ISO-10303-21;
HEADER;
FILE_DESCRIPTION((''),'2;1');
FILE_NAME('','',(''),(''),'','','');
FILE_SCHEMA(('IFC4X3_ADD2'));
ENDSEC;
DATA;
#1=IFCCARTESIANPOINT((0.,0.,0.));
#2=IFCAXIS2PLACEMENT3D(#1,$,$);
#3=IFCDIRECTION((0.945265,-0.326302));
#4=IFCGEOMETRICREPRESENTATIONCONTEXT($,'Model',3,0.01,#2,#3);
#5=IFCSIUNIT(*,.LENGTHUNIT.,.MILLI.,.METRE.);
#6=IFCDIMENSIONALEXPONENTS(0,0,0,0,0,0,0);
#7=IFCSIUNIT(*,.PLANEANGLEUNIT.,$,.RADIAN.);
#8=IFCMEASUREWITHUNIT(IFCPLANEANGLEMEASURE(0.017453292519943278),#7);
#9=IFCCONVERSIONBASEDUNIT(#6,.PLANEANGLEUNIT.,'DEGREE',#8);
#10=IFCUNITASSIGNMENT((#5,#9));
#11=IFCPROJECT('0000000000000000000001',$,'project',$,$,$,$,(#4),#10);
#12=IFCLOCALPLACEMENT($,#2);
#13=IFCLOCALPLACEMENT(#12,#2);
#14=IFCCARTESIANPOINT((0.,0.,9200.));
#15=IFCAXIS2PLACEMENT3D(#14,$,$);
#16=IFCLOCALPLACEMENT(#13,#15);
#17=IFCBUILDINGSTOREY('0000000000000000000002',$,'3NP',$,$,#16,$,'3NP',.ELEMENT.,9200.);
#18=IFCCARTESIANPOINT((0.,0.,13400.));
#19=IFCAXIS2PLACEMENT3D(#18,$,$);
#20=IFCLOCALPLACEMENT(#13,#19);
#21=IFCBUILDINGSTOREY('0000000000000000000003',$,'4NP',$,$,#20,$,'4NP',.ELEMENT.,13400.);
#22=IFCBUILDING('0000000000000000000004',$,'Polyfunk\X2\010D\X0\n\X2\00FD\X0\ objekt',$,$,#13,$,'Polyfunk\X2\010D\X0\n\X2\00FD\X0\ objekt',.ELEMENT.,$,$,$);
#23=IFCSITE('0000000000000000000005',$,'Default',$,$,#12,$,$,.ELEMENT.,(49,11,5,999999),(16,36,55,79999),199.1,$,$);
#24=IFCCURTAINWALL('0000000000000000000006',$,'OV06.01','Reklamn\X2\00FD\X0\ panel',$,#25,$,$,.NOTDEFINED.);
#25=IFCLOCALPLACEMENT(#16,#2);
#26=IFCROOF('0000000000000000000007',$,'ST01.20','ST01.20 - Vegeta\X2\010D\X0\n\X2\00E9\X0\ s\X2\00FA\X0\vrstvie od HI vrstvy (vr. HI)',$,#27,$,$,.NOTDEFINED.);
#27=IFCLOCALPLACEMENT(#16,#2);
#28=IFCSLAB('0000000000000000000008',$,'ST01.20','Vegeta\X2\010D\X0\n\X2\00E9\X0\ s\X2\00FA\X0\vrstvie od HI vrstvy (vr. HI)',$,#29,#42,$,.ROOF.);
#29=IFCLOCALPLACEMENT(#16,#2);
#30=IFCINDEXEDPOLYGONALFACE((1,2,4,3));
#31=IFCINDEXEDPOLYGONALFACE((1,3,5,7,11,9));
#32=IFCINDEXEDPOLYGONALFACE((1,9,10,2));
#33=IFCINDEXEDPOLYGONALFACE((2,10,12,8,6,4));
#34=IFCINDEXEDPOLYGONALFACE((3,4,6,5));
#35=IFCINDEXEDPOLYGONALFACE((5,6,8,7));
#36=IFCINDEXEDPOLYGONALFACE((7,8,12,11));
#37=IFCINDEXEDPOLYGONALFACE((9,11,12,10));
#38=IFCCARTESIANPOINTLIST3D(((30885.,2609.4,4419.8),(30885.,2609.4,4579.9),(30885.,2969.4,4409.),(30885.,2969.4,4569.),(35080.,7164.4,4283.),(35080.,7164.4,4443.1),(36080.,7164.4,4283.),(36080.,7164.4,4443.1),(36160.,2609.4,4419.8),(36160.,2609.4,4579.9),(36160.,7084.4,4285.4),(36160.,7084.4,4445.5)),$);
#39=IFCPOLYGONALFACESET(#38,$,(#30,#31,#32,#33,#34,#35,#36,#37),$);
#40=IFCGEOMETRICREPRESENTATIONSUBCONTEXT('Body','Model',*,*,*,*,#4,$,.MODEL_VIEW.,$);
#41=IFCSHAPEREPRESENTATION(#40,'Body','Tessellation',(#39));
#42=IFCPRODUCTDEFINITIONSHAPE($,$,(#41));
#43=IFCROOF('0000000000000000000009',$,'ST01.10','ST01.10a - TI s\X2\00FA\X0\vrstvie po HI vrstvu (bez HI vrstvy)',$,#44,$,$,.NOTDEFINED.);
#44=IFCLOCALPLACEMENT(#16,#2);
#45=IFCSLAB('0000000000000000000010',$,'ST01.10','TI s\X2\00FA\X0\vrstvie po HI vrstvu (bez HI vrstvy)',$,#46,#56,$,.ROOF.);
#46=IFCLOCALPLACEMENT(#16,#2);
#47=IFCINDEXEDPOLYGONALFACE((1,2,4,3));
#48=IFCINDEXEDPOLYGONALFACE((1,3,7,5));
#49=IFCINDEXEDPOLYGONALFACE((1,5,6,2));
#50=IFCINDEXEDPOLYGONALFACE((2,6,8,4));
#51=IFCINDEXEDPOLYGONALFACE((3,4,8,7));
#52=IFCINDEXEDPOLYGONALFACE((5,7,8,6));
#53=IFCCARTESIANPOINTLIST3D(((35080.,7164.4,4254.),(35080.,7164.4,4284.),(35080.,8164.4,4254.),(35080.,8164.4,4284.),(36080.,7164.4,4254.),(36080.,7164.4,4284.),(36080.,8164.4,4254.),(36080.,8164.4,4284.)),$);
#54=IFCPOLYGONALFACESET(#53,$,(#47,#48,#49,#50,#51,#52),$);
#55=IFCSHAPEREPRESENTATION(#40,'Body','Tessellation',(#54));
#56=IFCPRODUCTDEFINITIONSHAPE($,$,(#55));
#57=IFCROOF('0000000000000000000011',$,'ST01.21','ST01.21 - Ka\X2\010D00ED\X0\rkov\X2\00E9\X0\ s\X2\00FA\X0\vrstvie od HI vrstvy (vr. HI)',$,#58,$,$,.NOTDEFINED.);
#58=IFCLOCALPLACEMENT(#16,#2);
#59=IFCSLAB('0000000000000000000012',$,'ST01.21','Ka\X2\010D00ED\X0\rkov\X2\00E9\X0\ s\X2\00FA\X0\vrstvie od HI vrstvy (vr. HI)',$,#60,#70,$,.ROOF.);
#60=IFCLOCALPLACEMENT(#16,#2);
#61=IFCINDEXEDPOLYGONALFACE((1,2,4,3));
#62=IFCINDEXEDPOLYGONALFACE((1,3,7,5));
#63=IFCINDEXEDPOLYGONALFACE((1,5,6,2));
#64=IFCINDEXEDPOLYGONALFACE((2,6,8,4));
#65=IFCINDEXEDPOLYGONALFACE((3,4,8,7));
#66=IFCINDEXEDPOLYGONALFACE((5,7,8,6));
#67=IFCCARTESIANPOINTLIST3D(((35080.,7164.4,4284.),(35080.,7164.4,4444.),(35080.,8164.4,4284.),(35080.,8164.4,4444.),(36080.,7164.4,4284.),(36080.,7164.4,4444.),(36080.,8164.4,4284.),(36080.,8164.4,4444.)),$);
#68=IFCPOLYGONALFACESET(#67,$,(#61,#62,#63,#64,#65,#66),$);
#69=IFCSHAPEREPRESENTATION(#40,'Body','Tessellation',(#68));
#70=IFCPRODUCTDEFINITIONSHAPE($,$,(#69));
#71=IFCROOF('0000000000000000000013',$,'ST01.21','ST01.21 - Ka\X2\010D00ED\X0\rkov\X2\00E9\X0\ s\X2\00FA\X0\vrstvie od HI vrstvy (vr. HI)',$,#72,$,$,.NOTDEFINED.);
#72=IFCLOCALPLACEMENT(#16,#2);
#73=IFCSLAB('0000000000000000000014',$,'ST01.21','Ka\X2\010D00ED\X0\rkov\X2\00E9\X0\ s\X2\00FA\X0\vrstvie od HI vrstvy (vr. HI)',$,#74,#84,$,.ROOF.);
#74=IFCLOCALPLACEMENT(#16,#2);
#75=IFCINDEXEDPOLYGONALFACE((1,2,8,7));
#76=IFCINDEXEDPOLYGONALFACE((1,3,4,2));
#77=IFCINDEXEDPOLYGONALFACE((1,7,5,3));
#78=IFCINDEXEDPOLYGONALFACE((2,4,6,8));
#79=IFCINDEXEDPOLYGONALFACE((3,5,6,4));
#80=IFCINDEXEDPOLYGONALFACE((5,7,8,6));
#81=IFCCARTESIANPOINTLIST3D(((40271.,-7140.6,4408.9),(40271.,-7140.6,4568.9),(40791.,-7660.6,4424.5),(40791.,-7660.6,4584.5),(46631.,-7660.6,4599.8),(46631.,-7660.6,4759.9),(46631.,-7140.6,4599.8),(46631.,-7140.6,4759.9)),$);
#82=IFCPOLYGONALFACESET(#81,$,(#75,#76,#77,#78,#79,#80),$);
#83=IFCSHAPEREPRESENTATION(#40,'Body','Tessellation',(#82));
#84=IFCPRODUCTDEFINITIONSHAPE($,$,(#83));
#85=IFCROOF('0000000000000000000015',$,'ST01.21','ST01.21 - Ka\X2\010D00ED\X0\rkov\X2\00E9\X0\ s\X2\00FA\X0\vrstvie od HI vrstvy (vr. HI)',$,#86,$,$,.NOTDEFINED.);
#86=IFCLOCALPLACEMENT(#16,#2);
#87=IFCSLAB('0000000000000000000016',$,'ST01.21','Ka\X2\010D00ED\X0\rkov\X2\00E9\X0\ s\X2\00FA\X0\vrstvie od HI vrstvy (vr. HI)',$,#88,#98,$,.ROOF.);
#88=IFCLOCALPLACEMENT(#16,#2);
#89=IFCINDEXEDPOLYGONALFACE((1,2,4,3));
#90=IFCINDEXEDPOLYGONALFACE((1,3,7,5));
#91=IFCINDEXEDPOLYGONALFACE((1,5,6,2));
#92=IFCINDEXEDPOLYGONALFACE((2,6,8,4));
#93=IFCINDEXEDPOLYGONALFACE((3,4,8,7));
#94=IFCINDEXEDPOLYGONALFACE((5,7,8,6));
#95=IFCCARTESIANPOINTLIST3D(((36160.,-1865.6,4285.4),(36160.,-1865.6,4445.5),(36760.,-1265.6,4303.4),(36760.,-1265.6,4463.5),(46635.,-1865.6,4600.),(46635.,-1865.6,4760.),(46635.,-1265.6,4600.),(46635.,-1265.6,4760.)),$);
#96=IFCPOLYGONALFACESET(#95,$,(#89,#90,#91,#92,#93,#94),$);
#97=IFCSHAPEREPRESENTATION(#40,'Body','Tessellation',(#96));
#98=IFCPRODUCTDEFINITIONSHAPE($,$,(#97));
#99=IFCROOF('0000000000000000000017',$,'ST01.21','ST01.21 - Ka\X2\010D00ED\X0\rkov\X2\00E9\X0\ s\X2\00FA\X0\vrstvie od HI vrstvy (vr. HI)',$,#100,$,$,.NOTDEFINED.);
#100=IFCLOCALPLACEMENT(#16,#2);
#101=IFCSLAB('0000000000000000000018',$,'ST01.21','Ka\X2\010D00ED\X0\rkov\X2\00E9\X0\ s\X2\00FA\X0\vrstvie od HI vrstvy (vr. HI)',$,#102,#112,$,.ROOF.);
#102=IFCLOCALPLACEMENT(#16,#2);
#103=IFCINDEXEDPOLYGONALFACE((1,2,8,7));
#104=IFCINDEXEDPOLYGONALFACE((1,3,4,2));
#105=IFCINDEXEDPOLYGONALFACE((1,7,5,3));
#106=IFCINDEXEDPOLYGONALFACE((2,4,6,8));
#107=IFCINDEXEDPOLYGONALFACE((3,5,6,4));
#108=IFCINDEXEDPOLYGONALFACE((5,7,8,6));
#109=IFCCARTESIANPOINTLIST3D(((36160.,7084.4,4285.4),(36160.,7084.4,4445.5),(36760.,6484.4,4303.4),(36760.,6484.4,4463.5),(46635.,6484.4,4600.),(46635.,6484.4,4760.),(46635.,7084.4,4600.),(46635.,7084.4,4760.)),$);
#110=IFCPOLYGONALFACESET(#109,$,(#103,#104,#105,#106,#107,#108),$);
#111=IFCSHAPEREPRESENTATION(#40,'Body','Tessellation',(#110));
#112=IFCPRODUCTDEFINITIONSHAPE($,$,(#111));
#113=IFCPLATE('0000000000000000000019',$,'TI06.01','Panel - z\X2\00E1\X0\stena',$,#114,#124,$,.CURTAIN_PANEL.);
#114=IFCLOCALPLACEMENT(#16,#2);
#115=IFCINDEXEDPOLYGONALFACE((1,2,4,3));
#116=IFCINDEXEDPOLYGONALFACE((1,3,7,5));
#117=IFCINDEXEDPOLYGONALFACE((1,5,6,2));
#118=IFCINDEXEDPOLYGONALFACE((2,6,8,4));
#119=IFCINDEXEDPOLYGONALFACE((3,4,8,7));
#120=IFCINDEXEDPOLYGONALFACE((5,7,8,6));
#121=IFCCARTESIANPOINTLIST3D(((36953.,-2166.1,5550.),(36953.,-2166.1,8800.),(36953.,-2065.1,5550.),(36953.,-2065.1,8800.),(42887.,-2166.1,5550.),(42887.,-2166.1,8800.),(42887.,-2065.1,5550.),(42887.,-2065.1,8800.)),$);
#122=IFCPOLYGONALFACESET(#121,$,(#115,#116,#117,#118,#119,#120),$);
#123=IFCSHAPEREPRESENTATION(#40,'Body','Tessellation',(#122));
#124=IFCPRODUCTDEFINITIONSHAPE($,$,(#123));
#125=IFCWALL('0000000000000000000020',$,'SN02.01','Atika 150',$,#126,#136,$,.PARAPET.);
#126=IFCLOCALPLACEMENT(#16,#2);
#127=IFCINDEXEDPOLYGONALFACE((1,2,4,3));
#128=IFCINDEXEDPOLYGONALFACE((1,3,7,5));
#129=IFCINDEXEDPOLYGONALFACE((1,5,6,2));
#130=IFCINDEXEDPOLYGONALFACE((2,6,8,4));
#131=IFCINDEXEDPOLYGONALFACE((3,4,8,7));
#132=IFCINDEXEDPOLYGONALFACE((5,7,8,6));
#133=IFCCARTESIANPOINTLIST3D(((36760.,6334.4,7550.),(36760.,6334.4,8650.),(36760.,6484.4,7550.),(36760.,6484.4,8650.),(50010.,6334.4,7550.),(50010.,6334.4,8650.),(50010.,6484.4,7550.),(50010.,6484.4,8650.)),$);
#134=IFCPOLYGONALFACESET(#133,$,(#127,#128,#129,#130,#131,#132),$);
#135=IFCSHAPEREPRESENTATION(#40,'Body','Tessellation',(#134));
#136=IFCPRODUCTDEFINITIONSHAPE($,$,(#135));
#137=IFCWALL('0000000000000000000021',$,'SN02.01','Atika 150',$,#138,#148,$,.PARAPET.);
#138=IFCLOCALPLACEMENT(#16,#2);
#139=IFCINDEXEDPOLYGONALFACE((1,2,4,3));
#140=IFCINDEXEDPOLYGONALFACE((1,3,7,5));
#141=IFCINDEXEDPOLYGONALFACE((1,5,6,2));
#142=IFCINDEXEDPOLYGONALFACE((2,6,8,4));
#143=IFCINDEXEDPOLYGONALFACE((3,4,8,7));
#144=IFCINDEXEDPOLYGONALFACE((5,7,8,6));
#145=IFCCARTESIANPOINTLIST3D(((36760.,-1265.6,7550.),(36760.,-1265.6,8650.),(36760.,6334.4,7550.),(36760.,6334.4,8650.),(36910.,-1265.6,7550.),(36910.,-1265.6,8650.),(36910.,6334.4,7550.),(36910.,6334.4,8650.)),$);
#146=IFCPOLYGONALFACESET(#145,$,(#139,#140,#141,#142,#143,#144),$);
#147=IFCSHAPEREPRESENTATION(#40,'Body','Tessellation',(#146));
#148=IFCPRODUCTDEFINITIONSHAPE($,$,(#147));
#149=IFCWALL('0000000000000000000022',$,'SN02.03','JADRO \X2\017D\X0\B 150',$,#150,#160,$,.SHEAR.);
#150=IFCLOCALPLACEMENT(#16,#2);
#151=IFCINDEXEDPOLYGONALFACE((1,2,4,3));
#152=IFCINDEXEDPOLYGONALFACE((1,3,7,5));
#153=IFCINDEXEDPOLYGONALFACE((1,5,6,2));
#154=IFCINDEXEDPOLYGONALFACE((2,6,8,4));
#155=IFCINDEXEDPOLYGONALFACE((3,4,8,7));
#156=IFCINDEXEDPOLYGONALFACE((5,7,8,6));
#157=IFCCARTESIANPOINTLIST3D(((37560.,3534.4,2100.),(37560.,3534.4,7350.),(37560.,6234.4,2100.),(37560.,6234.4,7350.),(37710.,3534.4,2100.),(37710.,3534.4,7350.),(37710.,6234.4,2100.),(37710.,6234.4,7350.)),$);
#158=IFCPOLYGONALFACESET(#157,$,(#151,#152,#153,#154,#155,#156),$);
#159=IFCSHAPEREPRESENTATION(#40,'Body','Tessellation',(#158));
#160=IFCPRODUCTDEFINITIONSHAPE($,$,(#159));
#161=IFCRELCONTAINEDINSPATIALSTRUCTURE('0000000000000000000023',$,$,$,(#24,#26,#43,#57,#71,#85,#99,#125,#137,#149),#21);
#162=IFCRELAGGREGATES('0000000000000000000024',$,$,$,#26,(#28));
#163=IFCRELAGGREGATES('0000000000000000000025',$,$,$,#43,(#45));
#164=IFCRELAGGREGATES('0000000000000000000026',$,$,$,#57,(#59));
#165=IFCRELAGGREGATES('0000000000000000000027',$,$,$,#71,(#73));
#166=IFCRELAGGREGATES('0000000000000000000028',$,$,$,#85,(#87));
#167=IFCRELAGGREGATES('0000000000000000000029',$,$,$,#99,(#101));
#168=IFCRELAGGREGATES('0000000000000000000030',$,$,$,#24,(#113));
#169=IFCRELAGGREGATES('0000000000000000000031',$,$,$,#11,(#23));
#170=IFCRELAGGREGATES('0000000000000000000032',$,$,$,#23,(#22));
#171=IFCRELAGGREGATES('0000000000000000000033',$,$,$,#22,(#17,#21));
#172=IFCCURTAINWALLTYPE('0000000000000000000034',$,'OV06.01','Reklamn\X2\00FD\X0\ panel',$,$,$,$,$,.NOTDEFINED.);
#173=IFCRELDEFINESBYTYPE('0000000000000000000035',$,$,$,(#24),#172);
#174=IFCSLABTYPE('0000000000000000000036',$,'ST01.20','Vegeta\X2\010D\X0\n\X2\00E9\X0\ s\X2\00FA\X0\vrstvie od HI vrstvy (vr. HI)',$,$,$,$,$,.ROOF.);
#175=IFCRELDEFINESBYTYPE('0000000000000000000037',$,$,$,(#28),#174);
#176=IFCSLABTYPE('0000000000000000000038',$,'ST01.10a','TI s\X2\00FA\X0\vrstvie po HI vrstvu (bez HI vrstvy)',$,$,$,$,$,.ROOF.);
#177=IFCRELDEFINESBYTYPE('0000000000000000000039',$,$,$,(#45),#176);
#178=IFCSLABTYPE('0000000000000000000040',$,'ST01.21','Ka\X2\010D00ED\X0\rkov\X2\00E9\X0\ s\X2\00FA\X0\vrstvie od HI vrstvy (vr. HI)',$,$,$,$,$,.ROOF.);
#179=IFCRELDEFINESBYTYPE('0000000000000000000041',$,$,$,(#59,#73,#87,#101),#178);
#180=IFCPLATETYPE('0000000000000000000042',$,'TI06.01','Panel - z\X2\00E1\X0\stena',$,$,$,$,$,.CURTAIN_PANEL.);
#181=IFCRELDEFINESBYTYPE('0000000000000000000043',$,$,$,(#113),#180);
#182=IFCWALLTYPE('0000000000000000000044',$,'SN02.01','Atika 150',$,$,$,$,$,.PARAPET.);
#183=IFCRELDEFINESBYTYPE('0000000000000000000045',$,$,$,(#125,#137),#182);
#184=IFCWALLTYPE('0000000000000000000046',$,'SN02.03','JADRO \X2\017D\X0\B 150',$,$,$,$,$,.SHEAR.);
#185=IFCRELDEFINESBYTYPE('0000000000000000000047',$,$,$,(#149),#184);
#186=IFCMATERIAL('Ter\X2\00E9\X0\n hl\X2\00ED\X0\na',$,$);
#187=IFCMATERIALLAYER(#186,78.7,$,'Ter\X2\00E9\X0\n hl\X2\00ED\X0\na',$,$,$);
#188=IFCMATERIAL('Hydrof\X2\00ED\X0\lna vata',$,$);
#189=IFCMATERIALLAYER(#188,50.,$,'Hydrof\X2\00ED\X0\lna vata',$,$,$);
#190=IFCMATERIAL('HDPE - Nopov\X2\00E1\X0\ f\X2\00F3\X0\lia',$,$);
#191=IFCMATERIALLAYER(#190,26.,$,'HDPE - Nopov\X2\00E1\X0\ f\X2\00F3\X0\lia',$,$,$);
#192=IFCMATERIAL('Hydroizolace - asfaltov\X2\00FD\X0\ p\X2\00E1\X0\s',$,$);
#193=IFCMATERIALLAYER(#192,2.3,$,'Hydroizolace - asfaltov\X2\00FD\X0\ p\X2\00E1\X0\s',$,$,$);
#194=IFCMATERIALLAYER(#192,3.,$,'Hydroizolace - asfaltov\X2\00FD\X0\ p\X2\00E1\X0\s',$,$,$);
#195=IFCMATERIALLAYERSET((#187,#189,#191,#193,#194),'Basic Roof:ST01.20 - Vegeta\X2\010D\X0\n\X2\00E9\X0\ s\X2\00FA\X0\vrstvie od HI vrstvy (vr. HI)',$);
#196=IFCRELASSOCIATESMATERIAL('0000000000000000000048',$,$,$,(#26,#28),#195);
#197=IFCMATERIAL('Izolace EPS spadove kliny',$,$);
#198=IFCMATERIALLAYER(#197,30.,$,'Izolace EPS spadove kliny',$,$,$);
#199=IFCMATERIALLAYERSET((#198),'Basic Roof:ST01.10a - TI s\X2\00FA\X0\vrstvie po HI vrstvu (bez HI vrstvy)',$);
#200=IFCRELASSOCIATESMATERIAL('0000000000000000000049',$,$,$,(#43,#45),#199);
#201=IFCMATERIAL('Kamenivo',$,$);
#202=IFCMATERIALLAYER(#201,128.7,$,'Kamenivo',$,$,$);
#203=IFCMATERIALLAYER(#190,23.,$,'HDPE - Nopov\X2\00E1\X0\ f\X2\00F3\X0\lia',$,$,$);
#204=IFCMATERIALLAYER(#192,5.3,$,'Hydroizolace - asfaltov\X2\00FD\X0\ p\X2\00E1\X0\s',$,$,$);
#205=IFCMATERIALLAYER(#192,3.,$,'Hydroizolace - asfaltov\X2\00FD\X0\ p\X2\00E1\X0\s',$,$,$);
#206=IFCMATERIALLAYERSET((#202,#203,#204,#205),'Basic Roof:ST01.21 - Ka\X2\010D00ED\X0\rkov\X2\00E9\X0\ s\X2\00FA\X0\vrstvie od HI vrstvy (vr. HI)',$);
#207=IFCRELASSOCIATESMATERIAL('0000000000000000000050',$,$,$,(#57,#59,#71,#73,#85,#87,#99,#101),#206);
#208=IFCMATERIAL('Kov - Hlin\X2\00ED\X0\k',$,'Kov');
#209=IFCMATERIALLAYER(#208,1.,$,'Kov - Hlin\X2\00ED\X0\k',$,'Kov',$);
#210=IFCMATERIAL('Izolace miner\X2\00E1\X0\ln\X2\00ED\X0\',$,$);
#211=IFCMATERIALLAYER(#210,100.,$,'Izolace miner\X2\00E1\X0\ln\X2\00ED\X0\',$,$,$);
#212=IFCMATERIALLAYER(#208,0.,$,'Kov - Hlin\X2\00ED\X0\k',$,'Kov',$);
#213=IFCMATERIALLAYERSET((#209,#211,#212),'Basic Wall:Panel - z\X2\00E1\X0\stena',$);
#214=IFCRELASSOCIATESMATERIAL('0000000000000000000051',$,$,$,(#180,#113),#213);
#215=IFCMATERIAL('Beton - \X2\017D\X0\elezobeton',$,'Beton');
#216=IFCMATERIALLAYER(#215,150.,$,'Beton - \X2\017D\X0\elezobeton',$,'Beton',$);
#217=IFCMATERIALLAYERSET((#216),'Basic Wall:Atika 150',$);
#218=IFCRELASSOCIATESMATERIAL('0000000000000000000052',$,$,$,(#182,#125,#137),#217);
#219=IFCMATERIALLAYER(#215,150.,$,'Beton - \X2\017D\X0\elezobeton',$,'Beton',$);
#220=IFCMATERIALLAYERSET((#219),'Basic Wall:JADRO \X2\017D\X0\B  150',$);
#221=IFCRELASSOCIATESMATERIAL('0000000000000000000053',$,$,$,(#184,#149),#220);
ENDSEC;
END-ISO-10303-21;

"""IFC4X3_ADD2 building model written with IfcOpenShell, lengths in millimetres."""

from ifc_helpers import new_model, entity, si_unit, converted_unit, direction, frame, frame_2d, origin, place, context, subcontext, project, spatial, polyline, rectangle, outline, extrude, material, layer, layer_set, layer_usage, type_object, element, aggregate, save


model = new_model("IFC4X3_ADD2")

# Units and contexts
model_context = context("Model", 3, precision=0.01, world=origin(), true_north=direction((0.945265, -0.326302)))
body_context = subcontext(model_context, "Body", "Model", "MODEL_VIEW")
ifc_project = project(units=[si_unit("LENGTHUNIT", "METRE", prefix="MILLI"), converted_unit("PLANEANGLEUNIT", "DEGREE", entity("IfcPlaneAngleMeasure", 0.017453292519943278), si_unit("PLANEANGLEUNIT", "RADIAN"), dimensions=[0, 0, 0, 0, 0, 0, 0])], contexts=[model_context])

# Site, building, storey
site_placement = place(None, origin())
site = spatial("IfcSite", under=ifc_project, at=site_placement, Name="Default", CompositionType="ELEMENT", RefLatitude=(49, 11, 5, 999999), RefLongitude=(16, 36, 55, 79999), RefElevation=199.1)
building_placement = place(site_placement, origin())
building = spatial("IfcBuilding", under=site, at=building_placement, Name="Polyfunkčný objekt", LongName="Polyfunkčný objekt", CompositionType="ELEMENT")
storey_1_placement = place(building_placement, frame((0.0, 0.0, 9200.0)))
storey_1 = spatial("IfcBuildingStorey", under=building, at=storey_1_placement, Name="3NP", LongName="3NP", CompositionType="ELEMENT", Elevation=9200.0)

# Shared definitions
storey_2_placement = place(building_placement, frame((0.0, 0.0, 13400.0)))
storey_2 = spatial("IfcBuildingStorey", under=building, at=storey_2_placement, Name="4NP", LongName="4NP", CompositionType="ELEMENT", Elevation=13400.0)

# Curtain wall
curtain_wall_type_1 = type_object("IfcCurtainWallType", Name="OV06.01", Description="Reklamný panel", PredefinedType="NOTDEFINED")
curtain_wall_1_placement = place(storey_2_placement, frame((0.0, 0.0, -13400.0)))
curtain_wall_1 = element("IfcCurtainWall", 1, at=curtain_wall_1_placement, inside=storey_2, type_object=curtain_wall_type_1, Name="OV06.01", Description="Reklamný panel", PredefinedType="NOTDEFINED")

# Roofs, slabs
ifc_material_1 = material(Name="Terén hlína")
ifc_layer_1 = layer(ifc_material_1, 78.7, Name="Terén hlína")
ifc_material_2 = material(Name="Hydrofílna vata")
ifc_layer_2 = layer(ifc_material_2, 50.0, Name="Hydrofílna vata")
ifc_material_3 = material(Name="HDPE - Nopová fólia")
ifc_layer_3 = layer(ifc_material_3, 26.0, Name="HDPE - Nopová fólia")
ifc_material_4 = material(Name="Hydroizolace - asfaltový pás")
ifc_layer_4 = layer(ifc_material_4, 2.3, Name="Hydroizolace - asfaltový pás")
ifc_layer_5 = layer(ifc_material_4, 3.0, Name="Hydroizolace - asfaltový pás")
ifc_layer_set_1 = layer_set([ifc_layer_1, ifc_layer_2, ifc_layer_3, ifc_layer_4, ifc_layer_5], Name="Basic Roof:ST01.20 - Vegetačné súvrstvie od HI vrstvy (vr. HI)")
slab_type_1 = type_object("IfcSlabType", Name="ST01.20", Description="Vegetačné súvrstvie od HI vrstvy (vr. HI)", PredefinedType="ROOF")
roof_1_placement = place(storey_2_placement, frame((30885.0, 2609.4, 83.0)))
roof_1 = element("IfcRoof", 2, at=roof_1_placement, inside=storey_2, material=ifc_layer_set_1, Name="ST01.20", Description="ST01.20 - Vegetačné súvrstvie od HI vrstvy (vr. HI)", PredefinedType="NOTDEFINED")
slab_1_placement = place(roof_1_placement, origin())
slab_1 = element("IfcSlab", 3, at=slab_1_placement, type_object=slab_type_1, material=ifc_layer_set_1, Name="ST01.20", Description="Vegetačné súvrstvie od HI vrstvy (vr. HI)", PredefinedType="ROOF", context=body_context, shape_type="SweptSolid", body=[
    extrude(outline(polyline([(1557.5, 2278.5), (-2637.5, -1918.4), (-2637.5, -2278.5), (2637.5, -2278.5), (2637.5, 2198.5), (2557.5, 2278.5), (1557.5, 2278.5)])), frame((2637.5, 2277.5, 68.4), z_axis=(0.0, 0.030015, 0.999549), x_axis=(1.0, 0.0, 0.0)), (0.0, -0.030015, 0.999549), 160.1),
])
aggregate(roof_1, [slab_1])
ifc_material_5 = material(Name="Izolace EPS spadove kliny")
ifc_layer_6 = layer(ifc_material_5, 30.0, Name="Izolace EPS spadove kliny")
ifc_layer_set_2 = layer_set([ifc_layer_6], Name="Basic Roof:ST01.10a - TI súvrstvie po HI vrstvu (bez HI vrstvy)")
roof_2_placement = place(storey_2_placement, frame((35080.0, 7164.4, 54.0)))
roof_2 = element("IfcRoof", 4, at=roof_2_placement, inside=storey_2, material=ifc_layer_set_2, Name="ST01.10", Description="ST01.10a - TI súvrstvie po HI vrstvu (bez HI vrstvy)", PredefinedType="NOTDEFINED")
slab_type_2 = type_object("IfcSlabType", Name="ST01.10a", Description="TI súvrstvie po HI vrstvu (bez HI vrstvy)", PredefinedType="ROOF")
slab_2_placement = place(roof_2_placement, origin())
slab_2 = element("IfcSlab", 5, at=slab_2_placement, type_object=slab_type_2, material=ifc_layer_set_2, Name="ST01.10", Description="TI súvrstvie po HI vrstvu (bez HI vrstvy)", PredefinedType="ROOF", context=body_context, shape_type="SweptSolid", body=[
    extrude(rectangle(XDim=1000.0, YDim=1000.0, at=frame_2d((0.0, 0.0), x_axis=(1.0, 0.0))), frame((500.0, 500.0, 0.0)), (0.0, 0.0, 1.0), 30.0),
])
aggregate(roof_2, [slab_2])
ifc_material_6 = material(Name="Kamenivo")
ifc_layer_7 = layer(ifc_material_6, 128.7, Name="Kamenivo")
ifc_layer_8 = layer(ifc_material_3, 23.0, Name="HDPE - Nopová fólia")
ifc_layer_9 = layer(ifc_material_4, 5.3, Name="Hydroizolace - asfaltový pás")
ifc_layer_10 = layer(ifc_material_4, 3.0, Name="Hydroizolace - asfaltový pás")
ifc_layer_set_3 = layer_set([ifc_layer_7, ifc_layer_8, ifc_layer_9, ifc_layer_10], Name="Basic Roof:ST01.21 - Kačírkové súvrstvie od HI vrstvy (vr. HI)")
roof_3_placement = place(storey_2_placement, frame((35080.0, 7164.4, 84.0)))
roof_3 = element("IfcRoof", 6, at=roof_3_placement, inside=storey_2, material=ifc_layer_set_3, Name="ST01.21", Description="ST01.21 - Kačírkové súvrstvie od HI vrstvy (vr. HI)", PredefinedType="NOTDEFINED")
slab_type_3 = type_object("IfcSlabType", Name="ST01.21", Description="Kačírkové súvrstvie od HI vrstvy (vr. HI)", PredefinedType="ROOF")
slab_3_placement = place(roof_3_placement, origin())
slab_3 = element("IfcSlab", 7, at=slab_3_placement, type_object=slab_type_3, material=ifc_layer_set_3, Name="ST01.21", Description="Kačírkové súvrstvie od HI vrstvy (vr. HI)", PredefinedType="ROOF", context=body_context, shape_type="SweptSolid", body=[
    extrude(rectangle(XDim=1000.0, YDim=1000.0, at=frame_2d((0.0, 0.0), x_axis=(1.0, 0.0))), frame((500.0, 500.0, 0.0)), (0.0, 0.0, 1.0), 160.0),
])
aggregate(roof_3, [slab_3])
roof_4_placement = place(storey_2_placement, frame((40271.0, -7660.6, 208.9)))
roof_4 = element("IfcRoof", 8, at=roof_4_placement, inside=storey_2, material=ifc_layer_set_3, Name="ST01.21", Description="ST01.21 - Kačírkové súvrstvie od HI vrstvy (vr. HI)", PredefinedType="NOTDEFINED")
slab_4_placement = place(roof_4_placement, origin())
slab_4 = element("IfcSlab", 9, at=slab_4_placement, type_object=slab_type_3, material=ifc_layer_set_3, Name="ST01.21", Description="Kačírkové súvrstvie od HI vrstvy (vr. HI)", PredefinedType="ROOF", context=body_context, shape_type="SweptSolid", body=[
    extrude(outline(polyline([(-2661.2, -260.0), (3181.4, -260.0), (3181.4, 260.0), (-3181.4, 260.0), (-2661.2, -260.0)])), frame((3180.0, 260.0, 95.5), z_axis=(-0.030015, 0.0, 0.999549), x_axis=(0.999549, 0.0, 0.030015)), (0.030015, 0.0, 0.999549), 160.1),
])
aggregate(roof_4, [slab_4])
roof_5_placement = place(storey_2_placement, frame((36160.0, -1865.6, 85.4)))
roof_5 = element("IfcRoof", 10, at=roof_5_placement, inside=storey_2, material=ifc_layer_set_3, Name="ST01.21", Description="ST01.21 - Kačírkové súvrstvie od HI vrstvy (vr. HI)", PredefinedType="NOTDEFINED")
slab_5_placement = place(roof_5_placement, origin())
slab_5 = element("IfcSlab", 11, at=slab_5_placement, type_object=slab_type_3, material=ifc_layer_set_3, Name="ST01.21", Description="Kačírkové súvrstvie od HI vrstvy (vr. HI)", PredefinedType="ROOF", context=body_context, shape_type="SweptSolid", body=[
    extrude(outline(polyline([(-5239.9, -300.0), (5239.9, -300.0), (5239.9, 300.0), (-4639.6, 300.0), (-5239.9, -300.0)])), frame((5237.5, 300.0, 157.3), z_axis=(-0.030015, 0.0, 0.999549), x_axis=(0.999549, 0.0, 0.030015)), (0.030015, 0.0, 0.999549), 160.1),
])
aggregate(roof_5, [slab_5])
roof_6_placement = place(storey_2_placement, frame((36160.0, 6484.4, 85.4)))
roof_6 = element("IfcRoof", 12, at=roof_6_placement, inside=storey_2, material=ifc_layer_set_3, Name="ST01.21", Description="ST01.21 - Kačírkové súvrstvie od HI vrstvy (vr. HI)", PredefinedType="NOTDEFINED")
slab_6_placement = place(roof_6_placement, origin())
slab_6 = element("IfcSlab", 13, at=slab_6_placement, type_object=slab_type_3, material=ifc_layer_set_3, Name="ST01.21", Description="Kačírkové súvrstvie od HI vrstvy (vr. HI)", PredefinedType="ROOF", context=body_context, shape_type="SweptSolid", body=[
    extrude(outline(polyline([(-4639.6, -300.0), (5239.9, -300.0), (5239.9, 300.0), (-5239.9, 300.0), (-4639.6, -300.0)])), frame((5237.5, 300.0, 157.3), z_axis=(-0.030015, 0.0, 0.999549), x_axis=(0.999549, 0.0, 0.030015)), (0.030015, 0.0, 0.999549), 160.1),
])
aggregate(roof_6, [slab_6])

# Plate
ifc_material_7 = material(Name="Kov - Hliník", Category="Kov")
ifc_layer_11 = layer(ifc_material_7, 1.0, Name="Kov - Hliník", Category="Kov")
ifc_material_8 = material(Name="Izolace minerální")
ifc_layer_12 = layer(ifc_material_8, 100.0, Name="Izolace minerální")
ifc_layer_13 = layer(ifc_material_7, 0.0, Name="Kov - Hliník", Category="Kov")
ifc_layer_set_4 = layer_set([ifc_layer_11, ifc_layer_12, ifc_layer_13], Name="Basic Wall:Panel - zástena")
ifc_layer_usage = layer_usage(ifc_layer_set_4, "AXIS2", "NEGATIVE", 50.5)
plate_type = type_object("IfcPlateType", Name="TI06.01", Description="Panel - zástena", PredefinedType="CURTAIN_PANEL", material=ifc_layer_set_4)
plate_placement = place(storey_2_placement, frame((36953.0, -2115.6, 1350.0)))
plate = element("IfcPlate", 14, at=plate_placement, type_object=plate_type, material=ifc_layer_usage, Name="TI06.01", Description="Panel - zástena", PredefinedType="CURTAIN_PANEL", context=body_context, shape_type="SweptSolid", body=[
    extrude(rectangle(XDim=101.0, YDim=5934.0, at=frame_2d((0.0, 0.0), x_axis=(1.0, 0.0))), frame((2967.0, 0.0, 0.0), z_axis=(0.0, 0.0, 1.0), x_axis=(0.0, 1.0, 0.0)), (0.0, 0.0, 1.0), 3250.0),
])
aggregate(curtain_wall_1, [plate])

# Walls
ifc_material_9 = material(Name="Beton - Železobeton", Category="Beton")
ifc_layer_14 = layer(ifc_material_9, 150.0, Name="Beton - Železobeton", Category="Beton")
ifc_layer_set_5 = layer_set([ifc_layer_14], Name="Basic Wall:Atika 150")
wall_type_1 = type_object("IfcWallType", Name="SN02.01", Description="Atika 150", PredefinedType="PARAPET", material=ifc_layer_set_5)
wall_1_placement = place(storey_2_placement, frame((36760.0, 6409.4, 3350.0)))
element("IfcWall", 15, at=wall_1_placement, inside=storey_2, type_object=wall_type_1, material=ifc_layer_set_5, Name="SN02.01", Description="Atika 150", PredefinedType="PARAPET", context=body_context, shape_type="SweptSolid", body=[
    extrude(rectangle(XDim=13250.0, YDim=150.0, at=frame_2d((6625.0, 0.0), x_axis=(-1.0, 0.0))), origin(), (0.0, 0.0, 1.0), 1100.0),
])
wall_2_placement = place(storey_2_placement, frame((36835.0, 6334.4, 3350.0), z_axis=(0.0, 0.0, 1.0), x_axis=(0.0, -1.0, 0.0)))
element("IfcWall", 16, at=wall_2_placement, inside=storey_2, type_object=wall_type_1, material=ifc_layer_set_5, Name="SN02.01", Description="Atika 150", PredefinedType="PARAPET", context=body_context, shape_type="SweptSolid", body=[
    extrude(rectangle(XDim=7600.0, YDim=150.0, at=frame_2d((3800.0, 0.0), x_axis=(-1.0, 0.0))), origin(), (0.0, 0.0, 1.0), 1100.0),
])
ifc_layer_15 = layer(ifc_material_9, 150.0, Name="Beton - Železobeton", Category="Beton")
ifc_layer_set_6 = layer_set([ifc_layer_15], Name="Basic Wall:JADRO ŽB  150")
wall_type_2 = type_object("IfcWallType", Name="SN02.03", Description="JADRO ŽB 150", PredefinedType="SHEAR", material=ifc_layer_set_6)
wall_3_placement = place(storey_2_placement, frame((37635.0, 6234.4, -2100.0), z_axis=(0.0, 0.0, 1.0), x_axis=(0.0, -1.0, 0.0)))
element("IfcWall", 17, at=wall_3_placement, inside=storey_2, type_object=wall_type_2, material=ifc_layer_set_6, Name="SN02.03", Description="JADRO ŽB 150", PredefinedType="SHEAR", context=body_context, shape_type="SweptSolid", body=[
    extrude(rectangle(XDim=2700.0, YDim=150.0, at=frame_2d((1350.0, 0.0), x_axis=(-1.0, 0.0))), origin(), (0.0, 0.0, 1.0), 5250.0),
])

save(model, "model.ifc")
